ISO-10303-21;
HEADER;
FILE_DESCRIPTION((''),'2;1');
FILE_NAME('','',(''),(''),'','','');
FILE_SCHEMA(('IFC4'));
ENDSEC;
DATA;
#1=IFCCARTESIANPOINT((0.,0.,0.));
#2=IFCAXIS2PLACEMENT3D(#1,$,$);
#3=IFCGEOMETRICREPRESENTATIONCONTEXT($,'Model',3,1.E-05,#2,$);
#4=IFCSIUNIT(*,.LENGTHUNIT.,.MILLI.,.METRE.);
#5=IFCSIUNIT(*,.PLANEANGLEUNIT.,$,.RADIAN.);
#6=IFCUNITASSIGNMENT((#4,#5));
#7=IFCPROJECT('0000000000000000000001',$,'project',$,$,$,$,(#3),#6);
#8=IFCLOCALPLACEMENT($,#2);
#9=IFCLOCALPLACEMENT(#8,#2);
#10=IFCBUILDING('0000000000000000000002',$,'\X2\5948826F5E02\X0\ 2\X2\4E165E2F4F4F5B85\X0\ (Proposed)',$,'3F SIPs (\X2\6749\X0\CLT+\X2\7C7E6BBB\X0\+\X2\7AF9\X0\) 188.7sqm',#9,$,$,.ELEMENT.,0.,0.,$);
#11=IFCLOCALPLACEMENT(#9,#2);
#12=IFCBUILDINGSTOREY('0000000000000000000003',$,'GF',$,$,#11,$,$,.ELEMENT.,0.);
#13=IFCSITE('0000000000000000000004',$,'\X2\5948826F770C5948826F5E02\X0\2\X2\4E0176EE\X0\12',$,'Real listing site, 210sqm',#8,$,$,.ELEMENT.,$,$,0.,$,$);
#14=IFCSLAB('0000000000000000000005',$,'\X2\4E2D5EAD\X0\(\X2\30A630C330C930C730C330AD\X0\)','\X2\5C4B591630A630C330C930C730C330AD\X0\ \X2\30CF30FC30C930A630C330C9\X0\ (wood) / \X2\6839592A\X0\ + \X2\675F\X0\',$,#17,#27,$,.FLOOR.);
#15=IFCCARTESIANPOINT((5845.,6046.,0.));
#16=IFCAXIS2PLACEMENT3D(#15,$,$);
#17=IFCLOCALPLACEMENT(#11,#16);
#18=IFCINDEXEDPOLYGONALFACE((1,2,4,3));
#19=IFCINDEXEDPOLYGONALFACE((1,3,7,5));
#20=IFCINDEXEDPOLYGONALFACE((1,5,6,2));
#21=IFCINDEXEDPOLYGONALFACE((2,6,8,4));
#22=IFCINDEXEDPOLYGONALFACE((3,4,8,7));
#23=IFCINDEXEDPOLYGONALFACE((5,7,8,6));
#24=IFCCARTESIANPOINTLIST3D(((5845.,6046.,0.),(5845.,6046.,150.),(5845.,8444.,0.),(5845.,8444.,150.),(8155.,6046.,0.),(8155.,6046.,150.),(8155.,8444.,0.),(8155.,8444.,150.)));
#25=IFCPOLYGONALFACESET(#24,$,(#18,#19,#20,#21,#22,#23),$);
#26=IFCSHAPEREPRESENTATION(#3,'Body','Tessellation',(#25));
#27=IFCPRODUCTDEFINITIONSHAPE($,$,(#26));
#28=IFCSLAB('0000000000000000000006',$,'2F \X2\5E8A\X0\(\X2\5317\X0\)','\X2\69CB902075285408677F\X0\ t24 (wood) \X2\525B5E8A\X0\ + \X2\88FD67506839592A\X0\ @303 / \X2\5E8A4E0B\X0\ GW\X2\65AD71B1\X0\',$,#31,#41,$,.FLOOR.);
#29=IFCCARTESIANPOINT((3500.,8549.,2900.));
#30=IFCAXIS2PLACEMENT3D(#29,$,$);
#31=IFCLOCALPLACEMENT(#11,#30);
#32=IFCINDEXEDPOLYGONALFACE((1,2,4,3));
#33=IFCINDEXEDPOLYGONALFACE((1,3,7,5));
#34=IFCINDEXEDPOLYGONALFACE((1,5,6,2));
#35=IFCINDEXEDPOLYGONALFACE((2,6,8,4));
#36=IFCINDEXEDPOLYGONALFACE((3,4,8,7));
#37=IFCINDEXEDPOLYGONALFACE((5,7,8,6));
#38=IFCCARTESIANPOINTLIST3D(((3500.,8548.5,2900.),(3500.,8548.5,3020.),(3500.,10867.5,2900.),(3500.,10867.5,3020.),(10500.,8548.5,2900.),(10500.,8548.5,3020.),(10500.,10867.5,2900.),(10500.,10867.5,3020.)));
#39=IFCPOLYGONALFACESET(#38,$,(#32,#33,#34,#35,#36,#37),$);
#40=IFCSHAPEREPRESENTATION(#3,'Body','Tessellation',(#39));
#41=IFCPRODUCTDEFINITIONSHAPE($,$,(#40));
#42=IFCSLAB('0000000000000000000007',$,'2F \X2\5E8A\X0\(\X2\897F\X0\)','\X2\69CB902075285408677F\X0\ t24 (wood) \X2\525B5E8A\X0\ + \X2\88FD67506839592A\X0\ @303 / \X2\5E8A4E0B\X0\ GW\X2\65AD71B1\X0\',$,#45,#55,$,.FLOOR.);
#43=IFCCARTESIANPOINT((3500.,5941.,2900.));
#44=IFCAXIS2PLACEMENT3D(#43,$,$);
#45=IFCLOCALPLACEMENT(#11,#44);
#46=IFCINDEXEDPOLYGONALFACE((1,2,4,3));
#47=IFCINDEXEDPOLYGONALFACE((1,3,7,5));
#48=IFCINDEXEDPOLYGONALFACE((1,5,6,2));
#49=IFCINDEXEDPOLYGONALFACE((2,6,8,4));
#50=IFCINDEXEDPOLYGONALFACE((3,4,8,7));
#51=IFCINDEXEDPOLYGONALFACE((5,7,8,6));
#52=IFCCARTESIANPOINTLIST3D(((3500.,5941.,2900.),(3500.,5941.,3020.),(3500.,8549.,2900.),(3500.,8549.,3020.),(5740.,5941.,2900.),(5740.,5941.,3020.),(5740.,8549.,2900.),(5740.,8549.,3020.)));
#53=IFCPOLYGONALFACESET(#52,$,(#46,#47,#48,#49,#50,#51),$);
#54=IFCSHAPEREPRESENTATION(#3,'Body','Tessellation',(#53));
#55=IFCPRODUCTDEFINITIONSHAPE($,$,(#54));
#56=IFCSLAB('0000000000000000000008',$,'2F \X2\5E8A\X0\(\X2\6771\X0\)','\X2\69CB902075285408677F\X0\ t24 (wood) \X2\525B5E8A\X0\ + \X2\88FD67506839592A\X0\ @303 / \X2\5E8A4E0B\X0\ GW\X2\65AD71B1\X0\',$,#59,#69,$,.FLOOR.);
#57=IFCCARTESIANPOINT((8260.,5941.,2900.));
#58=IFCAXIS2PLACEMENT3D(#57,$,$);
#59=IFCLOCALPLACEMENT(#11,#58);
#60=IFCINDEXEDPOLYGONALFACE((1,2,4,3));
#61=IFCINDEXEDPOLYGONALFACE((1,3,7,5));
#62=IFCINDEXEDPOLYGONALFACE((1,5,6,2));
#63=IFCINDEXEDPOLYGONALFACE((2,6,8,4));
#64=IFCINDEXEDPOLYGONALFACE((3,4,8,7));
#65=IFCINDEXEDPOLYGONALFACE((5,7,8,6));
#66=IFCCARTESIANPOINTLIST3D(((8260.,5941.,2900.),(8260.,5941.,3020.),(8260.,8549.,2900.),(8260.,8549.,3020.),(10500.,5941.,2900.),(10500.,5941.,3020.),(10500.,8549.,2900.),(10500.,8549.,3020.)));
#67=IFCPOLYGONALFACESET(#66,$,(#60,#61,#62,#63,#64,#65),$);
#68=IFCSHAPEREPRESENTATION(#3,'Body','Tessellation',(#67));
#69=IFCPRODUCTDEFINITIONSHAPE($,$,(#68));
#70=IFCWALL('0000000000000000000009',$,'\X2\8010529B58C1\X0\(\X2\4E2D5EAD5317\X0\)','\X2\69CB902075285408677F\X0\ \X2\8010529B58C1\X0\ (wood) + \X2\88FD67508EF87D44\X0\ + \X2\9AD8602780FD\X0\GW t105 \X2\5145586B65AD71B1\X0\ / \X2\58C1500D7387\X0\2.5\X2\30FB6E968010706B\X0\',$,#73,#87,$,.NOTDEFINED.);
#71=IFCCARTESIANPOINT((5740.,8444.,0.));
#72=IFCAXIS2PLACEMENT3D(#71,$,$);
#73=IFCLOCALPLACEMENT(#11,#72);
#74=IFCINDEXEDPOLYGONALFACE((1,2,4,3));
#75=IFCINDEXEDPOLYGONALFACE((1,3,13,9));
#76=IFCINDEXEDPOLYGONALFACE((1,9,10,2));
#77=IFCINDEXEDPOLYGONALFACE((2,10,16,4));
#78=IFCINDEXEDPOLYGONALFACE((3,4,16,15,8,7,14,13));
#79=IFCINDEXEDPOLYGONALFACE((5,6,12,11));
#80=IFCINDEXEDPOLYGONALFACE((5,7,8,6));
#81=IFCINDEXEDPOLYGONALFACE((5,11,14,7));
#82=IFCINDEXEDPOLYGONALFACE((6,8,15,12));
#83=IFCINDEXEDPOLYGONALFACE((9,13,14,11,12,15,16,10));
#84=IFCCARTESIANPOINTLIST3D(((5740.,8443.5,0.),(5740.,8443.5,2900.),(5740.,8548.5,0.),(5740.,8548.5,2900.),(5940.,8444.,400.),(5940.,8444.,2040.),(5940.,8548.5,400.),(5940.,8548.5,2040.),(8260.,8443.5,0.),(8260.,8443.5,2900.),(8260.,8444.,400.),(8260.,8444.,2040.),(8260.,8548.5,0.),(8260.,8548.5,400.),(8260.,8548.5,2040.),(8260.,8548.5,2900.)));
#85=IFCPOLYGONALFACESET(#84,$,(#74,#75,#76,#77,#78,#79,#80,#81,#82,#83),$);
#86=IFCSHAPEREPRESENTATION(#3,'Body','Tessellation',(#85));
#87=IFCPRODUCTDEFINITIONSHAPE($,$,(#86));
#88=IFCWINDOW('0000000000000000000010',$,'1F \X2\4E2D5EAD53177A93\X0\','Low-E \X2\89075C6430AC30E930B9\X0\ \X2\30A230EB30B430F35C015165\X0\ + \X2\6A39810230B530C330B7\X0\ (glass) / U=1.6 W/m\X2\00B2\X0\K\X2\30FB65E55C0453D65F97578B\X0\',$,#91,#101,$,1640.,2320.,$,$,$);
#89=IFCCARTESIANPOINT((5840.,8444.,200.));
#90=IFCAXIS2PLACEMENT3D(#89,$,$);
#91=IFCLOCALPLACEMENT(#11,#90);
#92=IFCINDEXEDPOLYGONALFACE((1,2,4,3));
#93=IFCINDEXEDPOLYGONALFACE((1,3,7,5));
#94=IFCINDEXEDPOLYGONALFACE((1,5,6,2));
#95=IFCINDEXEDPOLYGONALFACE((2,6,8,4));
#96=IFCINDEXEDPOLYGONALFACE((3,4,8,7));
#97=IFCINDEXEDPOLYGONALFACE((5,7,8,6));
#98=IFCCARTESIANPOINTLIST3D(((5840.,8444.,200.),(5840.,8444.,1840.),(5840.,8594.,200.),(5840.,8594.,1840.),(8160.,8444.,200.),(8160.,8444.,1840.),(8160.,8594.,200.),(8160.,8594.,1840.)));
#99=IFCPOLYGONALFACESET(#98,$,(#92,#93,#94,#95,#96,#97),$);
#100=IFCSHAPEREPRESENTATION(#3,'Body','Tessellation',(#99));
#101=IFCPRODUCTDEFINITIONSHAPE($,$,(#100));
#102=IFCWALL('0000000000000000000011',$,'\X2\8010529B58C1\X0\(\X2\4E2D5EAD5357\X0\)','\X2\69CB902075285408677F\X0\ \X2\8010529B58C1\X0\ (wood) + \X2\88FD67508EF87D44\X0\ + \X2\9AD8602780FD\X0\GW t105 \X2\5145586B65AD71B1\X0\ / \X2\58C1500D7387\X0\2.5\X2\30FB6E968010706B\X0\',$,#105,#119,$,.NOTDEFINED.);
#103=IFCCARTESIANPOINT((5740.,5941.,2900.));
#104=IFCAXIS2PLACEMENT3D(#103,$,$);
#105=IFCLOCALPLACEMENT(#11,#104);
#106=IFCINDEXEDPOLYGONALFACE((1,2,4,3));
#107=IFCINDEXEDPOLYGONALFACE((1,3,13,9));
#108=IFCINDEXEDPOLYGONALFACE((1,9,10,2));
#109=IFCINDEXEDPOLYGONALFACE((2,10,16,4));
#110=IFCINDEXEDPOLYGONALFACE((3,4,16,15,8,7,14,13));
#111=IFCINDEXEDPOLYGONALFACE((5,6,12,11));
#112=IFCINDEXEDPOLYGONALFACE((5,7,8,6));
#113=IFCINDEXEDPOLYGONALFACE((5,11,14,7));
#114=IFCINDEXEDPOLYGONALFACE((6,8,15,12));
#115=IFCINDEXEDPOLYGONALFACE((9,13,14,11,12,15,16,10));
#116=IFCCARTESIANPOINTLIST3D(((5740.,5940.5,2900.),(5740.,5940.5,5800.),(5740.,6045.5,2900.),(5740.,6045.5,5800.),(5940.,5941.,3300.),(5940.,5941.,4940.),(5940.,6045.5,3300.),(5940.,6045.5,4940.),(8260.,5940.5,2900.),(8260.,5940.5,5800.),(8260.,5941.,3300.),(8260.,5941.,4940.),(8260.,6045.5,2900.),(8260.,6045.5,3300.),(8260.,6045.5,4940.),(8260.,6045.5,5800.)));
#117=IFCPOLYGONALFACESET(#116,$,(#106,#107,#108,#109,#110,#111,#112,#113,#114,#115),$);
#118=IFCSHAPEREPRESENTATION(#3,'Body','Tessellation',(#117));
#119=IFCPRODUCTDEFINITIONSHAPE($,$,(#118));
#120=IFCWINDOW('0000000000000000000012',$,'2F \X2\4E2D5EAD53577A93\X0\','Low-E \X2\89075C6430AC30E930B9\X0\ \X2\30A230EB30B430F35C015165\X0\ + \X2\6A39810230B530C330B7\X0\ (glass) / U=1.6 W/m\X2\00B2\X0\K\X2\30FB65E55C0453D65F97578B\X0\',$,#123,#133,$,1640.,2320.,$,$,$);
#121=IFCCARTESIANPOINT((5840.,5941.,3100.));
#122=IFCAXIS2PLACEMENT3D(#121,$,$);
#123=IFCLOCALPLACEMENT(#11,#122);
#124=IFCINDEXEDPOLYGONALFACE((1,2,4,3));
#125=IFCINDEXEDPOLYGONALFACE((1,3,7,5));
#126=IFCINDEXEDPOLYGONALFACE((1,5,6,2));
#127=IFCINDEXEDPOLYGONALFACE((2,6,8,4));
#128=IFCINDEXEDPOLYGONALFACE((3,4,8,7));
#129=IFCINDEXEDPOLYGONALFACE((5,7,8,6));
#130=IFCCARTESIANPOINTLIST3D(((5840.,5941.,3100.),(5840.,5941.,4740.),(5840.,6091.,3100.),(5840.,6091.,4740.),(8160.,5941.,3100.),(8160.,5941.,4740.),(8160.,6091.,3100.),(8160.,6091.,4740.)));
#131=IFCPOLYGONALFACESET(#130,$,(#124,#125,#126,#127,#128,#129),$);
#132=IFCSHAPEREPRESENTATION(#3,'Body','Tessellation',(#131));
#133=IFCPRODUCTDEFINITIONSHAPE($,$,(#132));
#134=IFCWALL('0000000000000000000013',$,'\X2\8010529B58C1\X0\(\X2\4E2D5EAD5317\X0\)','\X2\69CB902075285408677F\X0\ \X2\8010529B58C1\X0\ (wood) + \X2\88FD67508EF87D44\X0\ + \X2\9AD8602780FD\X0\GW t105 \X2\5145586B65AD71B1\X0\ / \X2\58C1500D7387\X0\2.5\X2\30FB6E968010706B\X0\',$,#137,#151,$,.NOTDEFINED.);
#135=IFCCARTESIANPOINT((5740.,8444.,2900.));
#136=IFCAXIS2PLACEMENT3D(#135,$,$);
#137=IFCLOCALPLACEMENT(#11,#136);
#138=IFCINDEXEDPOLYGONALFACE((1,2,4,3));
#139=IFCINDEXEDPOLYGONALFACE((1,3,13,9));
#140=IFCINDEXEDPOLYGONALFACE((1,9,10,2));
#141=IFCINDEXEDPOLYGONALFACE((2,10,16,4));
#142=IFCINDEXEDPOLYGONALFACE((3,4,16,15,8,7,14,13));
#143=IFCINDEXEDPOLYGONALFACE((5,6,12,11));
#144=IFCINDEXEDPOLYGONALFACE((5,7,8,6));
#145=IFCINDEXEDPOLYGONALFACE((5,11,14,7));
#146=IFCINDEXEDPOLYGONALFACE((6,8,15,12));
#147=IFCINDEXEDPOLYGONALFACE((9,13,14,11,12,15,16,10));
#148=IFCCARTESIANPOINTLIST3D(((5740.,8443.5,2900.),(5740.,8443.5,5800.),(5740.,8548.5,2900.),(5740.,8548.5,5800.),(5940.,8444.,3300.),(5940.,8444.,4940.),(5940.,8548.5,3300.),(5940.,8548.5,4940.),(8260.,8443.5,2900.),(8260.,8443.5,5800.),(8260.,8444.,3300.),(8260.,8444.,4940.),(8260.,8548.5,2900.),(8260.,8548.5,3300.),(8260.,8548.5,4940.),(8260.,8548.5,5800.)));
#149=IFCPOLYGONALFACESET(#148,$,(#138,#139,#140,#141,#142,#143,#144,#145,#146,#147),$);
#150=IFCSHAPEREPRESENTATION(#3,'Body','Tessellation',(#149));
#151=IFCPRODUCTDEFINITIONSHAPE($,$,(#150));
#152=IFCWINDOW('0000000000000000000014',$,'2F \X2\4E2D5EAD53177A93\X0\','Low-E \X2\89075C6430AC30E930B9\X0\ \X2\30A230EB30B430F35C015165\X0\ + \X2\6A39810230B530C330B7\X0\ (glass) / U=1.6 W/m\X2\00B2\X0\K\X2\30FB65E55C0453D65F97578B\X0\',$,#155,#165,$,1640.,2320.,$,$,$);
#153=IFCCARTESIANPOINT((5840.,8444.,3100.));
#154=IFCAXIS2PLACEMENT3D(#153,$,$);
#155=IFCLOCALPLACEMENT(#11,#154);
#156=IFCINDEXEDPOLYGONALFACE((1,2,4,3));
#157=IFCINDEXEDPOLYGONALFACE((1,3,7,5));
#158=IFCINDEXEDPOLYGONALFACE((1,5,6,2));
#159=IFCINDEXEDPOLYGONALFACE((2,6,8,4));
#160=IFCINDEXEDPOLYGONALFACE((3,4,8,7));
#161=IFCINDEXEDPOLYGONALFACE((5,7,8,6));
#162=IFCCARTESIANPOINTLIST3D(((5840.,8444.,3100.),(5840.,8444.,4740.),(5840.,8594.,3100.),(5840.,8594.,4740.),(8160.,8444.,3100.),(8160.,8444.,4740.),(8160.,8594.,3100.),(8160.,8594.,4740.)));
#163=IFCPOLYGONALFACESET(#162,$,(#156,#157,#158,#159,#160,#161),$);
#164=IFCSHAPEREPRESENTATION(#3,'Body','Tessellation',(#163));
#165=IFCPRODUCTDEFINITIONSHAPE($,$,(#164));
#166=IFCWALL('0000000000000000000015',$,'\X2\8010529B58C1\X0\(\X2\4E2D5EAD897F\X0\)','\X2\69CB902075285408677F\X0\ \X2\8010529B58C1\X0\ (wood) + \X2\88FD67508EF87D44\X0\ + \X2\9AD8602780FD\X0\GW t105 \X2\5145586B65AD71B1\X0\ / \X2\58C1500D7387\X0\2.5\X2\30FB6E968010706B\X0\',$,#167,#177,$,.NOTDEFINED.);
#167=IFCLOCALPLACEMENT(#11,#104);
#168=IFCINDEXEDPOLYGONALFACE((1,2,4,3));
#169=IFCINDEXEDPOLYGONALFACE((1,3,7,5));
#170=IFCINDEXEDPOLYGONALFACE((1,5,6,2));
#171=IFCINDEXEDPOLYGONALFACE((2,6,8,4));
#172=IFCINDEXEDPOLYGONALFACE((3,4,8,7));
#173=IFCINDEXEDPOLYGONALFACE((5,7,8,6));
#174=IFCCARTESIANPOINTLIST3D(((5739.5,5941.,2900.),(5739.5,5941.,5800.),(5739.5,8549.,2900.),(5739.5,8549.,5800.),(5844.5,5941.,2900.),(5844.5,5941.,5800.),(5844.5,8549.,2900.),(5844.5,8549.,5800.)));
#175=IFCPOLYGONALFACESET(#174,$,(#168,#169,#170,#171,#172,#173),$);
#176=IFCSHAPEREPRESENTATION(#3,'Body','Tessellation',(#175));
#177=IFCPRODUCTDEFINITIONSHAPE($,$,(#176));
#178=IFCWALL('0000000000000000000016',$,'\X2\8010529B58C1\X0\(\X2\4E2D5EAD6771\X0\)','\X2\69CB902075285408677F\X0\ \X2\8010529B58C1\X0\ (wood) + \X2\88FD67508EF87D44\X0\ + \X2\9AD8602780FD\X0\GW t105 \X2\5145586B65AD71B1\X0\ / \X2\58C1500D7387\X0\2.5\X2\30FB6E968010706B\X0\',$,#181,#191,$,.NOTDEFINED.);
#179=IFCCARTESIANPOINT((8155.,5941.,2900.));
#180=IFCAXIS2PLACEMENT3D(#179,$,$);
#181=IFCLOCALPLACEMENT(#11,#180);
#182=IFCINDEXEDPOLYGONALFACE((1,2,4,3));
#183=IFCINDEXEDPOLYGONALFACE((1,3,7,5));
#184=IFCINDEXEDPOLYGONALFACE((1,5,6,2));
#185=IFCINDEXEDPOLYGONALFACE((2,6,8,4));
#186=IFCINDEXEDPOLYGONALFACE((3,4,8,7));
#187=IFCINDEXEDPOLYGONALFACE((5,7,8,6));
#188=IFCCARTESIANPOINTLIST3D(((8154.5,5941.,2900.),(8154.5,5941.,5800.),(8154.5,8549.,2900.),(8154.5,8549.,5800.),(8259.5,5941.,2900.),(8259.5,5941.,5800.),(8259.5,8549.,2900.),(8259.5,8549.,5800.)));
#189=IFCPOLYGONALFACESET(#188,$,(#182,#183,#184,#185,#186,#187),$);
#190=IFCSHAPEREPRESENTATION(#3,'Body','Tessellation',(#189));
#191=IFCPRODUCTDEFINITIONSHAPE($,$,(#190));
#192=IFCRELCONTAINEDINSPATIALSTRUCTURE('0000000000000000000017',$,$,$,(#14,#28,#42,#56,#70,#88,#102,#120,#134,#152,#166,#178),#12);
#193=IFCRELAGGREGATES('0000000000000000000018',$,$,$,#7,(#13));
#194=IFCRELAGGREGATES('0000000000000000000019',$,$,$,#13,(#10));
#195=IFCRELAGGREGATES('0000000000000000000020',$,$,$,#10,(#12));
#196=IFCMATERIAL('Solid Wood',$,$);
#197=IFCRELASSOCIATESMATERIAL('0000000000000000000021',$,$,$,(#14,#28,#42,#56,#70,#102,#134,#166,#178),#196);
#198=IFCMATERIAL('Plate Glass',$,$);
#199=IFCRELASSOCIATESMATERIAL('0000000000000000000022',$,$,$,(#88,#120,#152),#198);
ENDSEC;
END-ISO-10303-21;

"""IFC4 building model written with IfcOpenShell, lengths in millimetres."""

from ifc_helpers import new_model, si_unit, frame, frame_2d, origin, place, context, project, spatial, rectangle, extrude, material, element, fill, save


model = new_model("IFC4")

# Units and contexts
model_context = context("Model", 3, precision=1e-05, world=origin())
ifc_project = project(units=[si_unit("LENGTHUNIT", "METRE", prefix="MILLI"), si_unit("PLANEANGLEUNIT", "RADIAN")], contexts=[model_context])

# Site, building, storey
site_placement = place(None, origin())
site = spatial("IfcSite", under=ifc_project, at=site_placement, Name="奈良県奈良市2丁目12", ObjectType="Real listing site, 210sqm", CompositionType="ELEMENT", RefElevation=0.0)
building_placement = place(site_placement, origin())
building = spatial("IfcBuilding", under=site, at=building_placement, Name="奈良市 2世帯住宅 (Proposed)", ObjectType="3F SIPs (杉CLT+籾殻+竹) 188.7sqm", CompositionType="ELEMENT", ElevationOfRefHeight=0.0, ElevationOfTerrain=0.0)
storey_placement = place(building_placement, origin())
storey = spatial("IfcBuildingStorey", under=building, at=storey_placement, Name="GF", CompositionType="ELEMENT", Elevation=0.0)

# Slabs
ifc_material_1 = material(Name="Solid Wood")
slab_1_placement = place(storey_placement, frame((5845.0, 6046.0, 0.0)))
element("IfcSlab", 1, at=slab_1_placement, inside=storey, material=ifc_material_1, Name="中庭(ウッドデッキ)", Description="屋外ウッドデッキ ハードウッド (wood) / 根太 + 束", PredefinedType="FLOOR", context=model_context, shape_type="SweptSolid", body=[
    extrude(rectangle(XDim=2310.0, YDim=2398.0, at=frame_2d((1155.0, 1199.0))), frame((5845.0, 6046.0, 0.0)), (0.0, 0.0, 1.0), 150.0),
])
slab_2_placement = place(storey_placement, frame((3500.0, 8549.0, 2900.0)))
element("IfcSlab", 2, at=slab_2_placement, inside=storey, material=ifc_material_1, Name="2F 床(北)", Description="構造用合板 t24 (wood) 剛床 + 製材根太 @303 / 床下 GW断熱", PredefinedType="FLOOR", context=model_context, shape_type="SweptSolid", body=[
    extrude(rectangle(XDim=7000.0, YDim=2319.0, at=frame_2d((3500.0, 1159.0))), frame((3500.0, 8549.0, 2900.0)), (0.0, 0.0, 1.0), 120.0),
])
slab_3_placement = place(storey_placement, frame((3500.0, 5941.0, 2900.0)))
element("IfcSlab", 3, at=slab_3_placement, inside=storey, material=ifc_material_1, Name="2F 床(西)", Description="構造用合板 t24 (wood) 剛床 + 製材根太 @303 / 床下 GW断熱", PredefinedType="FLOOR", context=model_context, shape_type="SweptSolid", body=[
    extrude(rectangle(XDim=2240.0, YDim=2608.0, at=frame_2d((1120.0, 1304.0))), frame((3500.0, 5941.0, 2900.0)), (0.0, 0.0, 1.0), 120.0),
])
slab_4_placement = place(storey_placement, frame((8260.0, 5941.0, 2900.0)))
element("IfcSlab", 4, at=slab_4_placement, inside=storey, material=ifc_material_1, Name="2F 床(東)", Description="構造用合板 t24 (wood) 剛床 + 製材根太 @303 / 床下 GW断熱", PredefinedType="FLOOR", context=model_context, shape_type="SweptSolid", body=[
    extrude(rectangle(XDim=2240.0, YDim=2608.0, at=frame_2d((1120.0, 1304.0))), frame((8260.0, 5941.0, 2900.0)), (0.0, 0.0, 1.0), 120.0),
])

# Wall, opening, window
wall_1_placement = place(storey_placement, frame((5740.0, 8444.0, 0.0)))
wall_1 = element("IfcWall", 5, at=wall_1_placement, inside=storey, material=ifc_material_1, Name="耐力壁(中庭北)", Description="構造用合板 耐力壁 (wood) + 製材軸組 + 高性能GW t105 充填断熱 / 壁倍率2.5・準耐火", PredefinedType="NOTDEFINED", context=model_context, shape_type="SweptSolid", body=[
    extrude(rectangle(XDim=2520.0, YDim=105.0, at=frame_2d((1260.0, 52.0))), frame((5740.0, 8444.0, 0.0)), (0.0, 0.0, 1.0), 2900.0),
])
opening_1_placement = place(storey_placement, frame((5840.0, 8444.0, 200.0)))
opening_1 = element("IfcOpeningElement", 6, at=opening_1_placement, cuts=wall_1, PredefinedType="NOTDEFINED", context=model_context, shape_type="SweptSolid", body=[
    extrude(rectangle(XDim=2320.0, YDim=150.0, at=frame_2d((1160.0, 75.0))), frame((5840.0, 8444.0, 200.0)), (0.0, 0.0, 1.0), 1640.0),
])
ifc_material_2 = material(Name="Plate Glass")
window_1_placement = place(storey_placement, frame((5840.0, 8444.0, 200.0)))
window_1 = element("IfcWindow", 7, at=window_1_placement, inside=storey, material=ifc_material_2, Name="1F 中庭北窓", Description="Low-E 複層ガラス アルゴン封入 + 樹脂サッシ (glass) / U=1.6 W/m²K・日射取得型", OverallHeight=1640.0, OverallWidth=2320.0, context=model_context, shape_type="SweptSolid", body=[
    extrude(rectangle(XDim=2320.0, YDim=150.0, at=frame_2d((1160.0, 75.0))), frame((5840.0, 8444.0, 200.0)), (0.0, 0.0, 1.0), 1640.0),
])
fill(opening_1, window_1)

# Walls, openings, windows
wall_2_placement = place(storey_placement, frame((5740.0, 5941.0, 2900.0)))
wall_2 = element("IfcWall", 8, at=wall_2_placement, inside=storey, material=ifc_material_1, Name="耐力壁(中庭南)", Description="構造用合板 耐力壁 (wood) + 製材軸組 + 高性能GW t105 充填断熱 / 壁倍率2.5・準耐火", PredefinedType="NOTDEFINED", context=model_context, shape_type="SweptSolid", body=[
    extrude(rectangle(XDim=2520.0, YDim=105.0, at=frame_2d((1260.0, 52.0))), frame((5740.0, 5941.0, 2900.0)), (0.0, 0.0, 1.0), 2900.0),
])
opening_2_placement = place(storey_placement, frame((5840.0, 5941.0, 3100.0)))
opening_2 = element("IfcOpeningElement", 9, at=opening_2_placement, cuts=wall_2, PredefinedType="NOTDEFINED", context=model_context, shape_type="SweptSolid", body=[
    extrude(rectangle(XDim=2320.0, YDim=150.0, at=frame_2d((1160.0, 75.0))), frame((5840.0, 5941.0, 3100.0)), (0.0, 0.0, 1.0), 1640.0),
])
window_2_placement = place(storey_placement, frame((5840.0, 5941.0, 3100.0)))
window_2 = element("IfcWindow", 10, at=window_2_placement, inside=storey, material=ifc_material_2, Name="2F 中庭南窓", Description="Low-E 複層ガラス アルゴン封入 + 樹脂サッシ (glass) / U=1.6 W/m²K・日射取得型", OverallHeight=1640.0, OverallWidth=2320.0, context=model_context, shape_type="SweptSolid", body=[
    extrude(rectangle(XDim=2320.0, YDim=150.0, at=frame_2d((1160.0, 75.0))), frame((5840.0, 5941.0, 3100.0)), (0.0, 0.0, 1.0), 1640.0),
])
fill(opening_2, window_2)
wall_3_placement = place(storey_placement, frame((5740.0, 8444.0, 2900.0)))
wall_3 = element("IfcWall", 11, at=wall_3_placement, inside=storey, material=ifc_material_1, Name="耐力壁(中庭北)", Description="構造用合板 耐力壁 (wood) + 製材軸組 + 高性能GW t105 充填断熱 / 壁倍率2.5・準耐火", PredefinedType="NOTDEFINED", context=model_context, shape_type="SweptSolid", body=[
    extrude(rectangle(XDim=2520.0, YDim=105.0, at=frame_2d((1260.0, 52.0))), frame((5740.0, 8444.0, 2900.0)), (0.0, 0.0, 1.0), 2900.0),
])
opening_3_placement = place(storey_placement, frame((5840.0, 8444.0, 3100.0)))
opening_3 = element("IfcOpeningElement", 12, at=opening_3_placement, cuts=wall_3, PredefinedType="NOTDEFINED", context=model_context, shape_type="SweptSolid", body=[
    extrude(rectangle(XDim=2320.0, YDim=150.0, at=frame_2d((1160.0, 75.0))), frame((5840.0, 8444.0, 3100.0)), (0.0, 0.0, 1.0), 1640.0),
])
window_3_placement = place(storey_placement, frame((5840.0, 8444.0, 3100.0)))
window_3 = element("IfcWindow", 13, at=window_3_placement, inside=storey, material=ifc_material_2, Name="2F 中庭北窓", Description="Low-E 複層ガラス アルゴン封入 + 樹脂サッシ (glass) / U=1.6 W/m²K・日射取得型", OverallHeight=1640.0, OverallWidth=2320.0, context=model_context, shape_type="SweptSolid", body=[
    extrude(rectangle(XDim=2320.0, YDim=150.0, at=frame_2d((1160.0, 75.0))), frame((5840.0, 8444.0, 3100.0)), (0.0, 0.0, 1.0), 1640.0),
])
fill(opening_3, window_3)

# Walls
wall_4_placement = place(storey_placement, frame((5740.0, 5941.0, 2900.0)))
element("IfcWall", 14, at=wall_4_placement, inside=storey, material=ifc_material_1, Name="耐力壁(中庭西)", Description="構造用合板 耐力壁 (wood) + 製材軸組 + 高性能GW t105 充填断熱 / 壁倍率2.5・準耐火", PredefinedType="NOTDEFINED", context=model_context, shape_type="SweptSolid", body=[
    extrude(rectangle(XDim=105.0, YDim=2608.0, at=frame_2d((52.0, 1304.0))), frame((5740.0, 5941.0, 2900.0)), (0.0, 0.0, 1.0), 2900.0),
])
wall_5_placement = place(storey_placement, frame((8155.0, 5941.0, 2900.0)))
element("IfcWall", 15, at=wall_5_placement, inside=storey, material=ifc_material_1, Name="耐力壁(中庭東)", Description="構造用合板 耐力壁 (wood) + 製材軸組 + 高性能GW t105 充填断熱 / 壁倍率2.5・準耐火", PredefinedType="NOTDEFINED", context=model_context, shape_type="SweptSolid", body=[
    extrude(rectangle(XDim=105.0, YDim=2608.0, at=frame_2d((52.0, 1304.0))), frame((8155.0, 5941.0, 2900.0)), (0.0, 0.0, 1.0), 2900.0),
])

save(model, "model.ifc")
